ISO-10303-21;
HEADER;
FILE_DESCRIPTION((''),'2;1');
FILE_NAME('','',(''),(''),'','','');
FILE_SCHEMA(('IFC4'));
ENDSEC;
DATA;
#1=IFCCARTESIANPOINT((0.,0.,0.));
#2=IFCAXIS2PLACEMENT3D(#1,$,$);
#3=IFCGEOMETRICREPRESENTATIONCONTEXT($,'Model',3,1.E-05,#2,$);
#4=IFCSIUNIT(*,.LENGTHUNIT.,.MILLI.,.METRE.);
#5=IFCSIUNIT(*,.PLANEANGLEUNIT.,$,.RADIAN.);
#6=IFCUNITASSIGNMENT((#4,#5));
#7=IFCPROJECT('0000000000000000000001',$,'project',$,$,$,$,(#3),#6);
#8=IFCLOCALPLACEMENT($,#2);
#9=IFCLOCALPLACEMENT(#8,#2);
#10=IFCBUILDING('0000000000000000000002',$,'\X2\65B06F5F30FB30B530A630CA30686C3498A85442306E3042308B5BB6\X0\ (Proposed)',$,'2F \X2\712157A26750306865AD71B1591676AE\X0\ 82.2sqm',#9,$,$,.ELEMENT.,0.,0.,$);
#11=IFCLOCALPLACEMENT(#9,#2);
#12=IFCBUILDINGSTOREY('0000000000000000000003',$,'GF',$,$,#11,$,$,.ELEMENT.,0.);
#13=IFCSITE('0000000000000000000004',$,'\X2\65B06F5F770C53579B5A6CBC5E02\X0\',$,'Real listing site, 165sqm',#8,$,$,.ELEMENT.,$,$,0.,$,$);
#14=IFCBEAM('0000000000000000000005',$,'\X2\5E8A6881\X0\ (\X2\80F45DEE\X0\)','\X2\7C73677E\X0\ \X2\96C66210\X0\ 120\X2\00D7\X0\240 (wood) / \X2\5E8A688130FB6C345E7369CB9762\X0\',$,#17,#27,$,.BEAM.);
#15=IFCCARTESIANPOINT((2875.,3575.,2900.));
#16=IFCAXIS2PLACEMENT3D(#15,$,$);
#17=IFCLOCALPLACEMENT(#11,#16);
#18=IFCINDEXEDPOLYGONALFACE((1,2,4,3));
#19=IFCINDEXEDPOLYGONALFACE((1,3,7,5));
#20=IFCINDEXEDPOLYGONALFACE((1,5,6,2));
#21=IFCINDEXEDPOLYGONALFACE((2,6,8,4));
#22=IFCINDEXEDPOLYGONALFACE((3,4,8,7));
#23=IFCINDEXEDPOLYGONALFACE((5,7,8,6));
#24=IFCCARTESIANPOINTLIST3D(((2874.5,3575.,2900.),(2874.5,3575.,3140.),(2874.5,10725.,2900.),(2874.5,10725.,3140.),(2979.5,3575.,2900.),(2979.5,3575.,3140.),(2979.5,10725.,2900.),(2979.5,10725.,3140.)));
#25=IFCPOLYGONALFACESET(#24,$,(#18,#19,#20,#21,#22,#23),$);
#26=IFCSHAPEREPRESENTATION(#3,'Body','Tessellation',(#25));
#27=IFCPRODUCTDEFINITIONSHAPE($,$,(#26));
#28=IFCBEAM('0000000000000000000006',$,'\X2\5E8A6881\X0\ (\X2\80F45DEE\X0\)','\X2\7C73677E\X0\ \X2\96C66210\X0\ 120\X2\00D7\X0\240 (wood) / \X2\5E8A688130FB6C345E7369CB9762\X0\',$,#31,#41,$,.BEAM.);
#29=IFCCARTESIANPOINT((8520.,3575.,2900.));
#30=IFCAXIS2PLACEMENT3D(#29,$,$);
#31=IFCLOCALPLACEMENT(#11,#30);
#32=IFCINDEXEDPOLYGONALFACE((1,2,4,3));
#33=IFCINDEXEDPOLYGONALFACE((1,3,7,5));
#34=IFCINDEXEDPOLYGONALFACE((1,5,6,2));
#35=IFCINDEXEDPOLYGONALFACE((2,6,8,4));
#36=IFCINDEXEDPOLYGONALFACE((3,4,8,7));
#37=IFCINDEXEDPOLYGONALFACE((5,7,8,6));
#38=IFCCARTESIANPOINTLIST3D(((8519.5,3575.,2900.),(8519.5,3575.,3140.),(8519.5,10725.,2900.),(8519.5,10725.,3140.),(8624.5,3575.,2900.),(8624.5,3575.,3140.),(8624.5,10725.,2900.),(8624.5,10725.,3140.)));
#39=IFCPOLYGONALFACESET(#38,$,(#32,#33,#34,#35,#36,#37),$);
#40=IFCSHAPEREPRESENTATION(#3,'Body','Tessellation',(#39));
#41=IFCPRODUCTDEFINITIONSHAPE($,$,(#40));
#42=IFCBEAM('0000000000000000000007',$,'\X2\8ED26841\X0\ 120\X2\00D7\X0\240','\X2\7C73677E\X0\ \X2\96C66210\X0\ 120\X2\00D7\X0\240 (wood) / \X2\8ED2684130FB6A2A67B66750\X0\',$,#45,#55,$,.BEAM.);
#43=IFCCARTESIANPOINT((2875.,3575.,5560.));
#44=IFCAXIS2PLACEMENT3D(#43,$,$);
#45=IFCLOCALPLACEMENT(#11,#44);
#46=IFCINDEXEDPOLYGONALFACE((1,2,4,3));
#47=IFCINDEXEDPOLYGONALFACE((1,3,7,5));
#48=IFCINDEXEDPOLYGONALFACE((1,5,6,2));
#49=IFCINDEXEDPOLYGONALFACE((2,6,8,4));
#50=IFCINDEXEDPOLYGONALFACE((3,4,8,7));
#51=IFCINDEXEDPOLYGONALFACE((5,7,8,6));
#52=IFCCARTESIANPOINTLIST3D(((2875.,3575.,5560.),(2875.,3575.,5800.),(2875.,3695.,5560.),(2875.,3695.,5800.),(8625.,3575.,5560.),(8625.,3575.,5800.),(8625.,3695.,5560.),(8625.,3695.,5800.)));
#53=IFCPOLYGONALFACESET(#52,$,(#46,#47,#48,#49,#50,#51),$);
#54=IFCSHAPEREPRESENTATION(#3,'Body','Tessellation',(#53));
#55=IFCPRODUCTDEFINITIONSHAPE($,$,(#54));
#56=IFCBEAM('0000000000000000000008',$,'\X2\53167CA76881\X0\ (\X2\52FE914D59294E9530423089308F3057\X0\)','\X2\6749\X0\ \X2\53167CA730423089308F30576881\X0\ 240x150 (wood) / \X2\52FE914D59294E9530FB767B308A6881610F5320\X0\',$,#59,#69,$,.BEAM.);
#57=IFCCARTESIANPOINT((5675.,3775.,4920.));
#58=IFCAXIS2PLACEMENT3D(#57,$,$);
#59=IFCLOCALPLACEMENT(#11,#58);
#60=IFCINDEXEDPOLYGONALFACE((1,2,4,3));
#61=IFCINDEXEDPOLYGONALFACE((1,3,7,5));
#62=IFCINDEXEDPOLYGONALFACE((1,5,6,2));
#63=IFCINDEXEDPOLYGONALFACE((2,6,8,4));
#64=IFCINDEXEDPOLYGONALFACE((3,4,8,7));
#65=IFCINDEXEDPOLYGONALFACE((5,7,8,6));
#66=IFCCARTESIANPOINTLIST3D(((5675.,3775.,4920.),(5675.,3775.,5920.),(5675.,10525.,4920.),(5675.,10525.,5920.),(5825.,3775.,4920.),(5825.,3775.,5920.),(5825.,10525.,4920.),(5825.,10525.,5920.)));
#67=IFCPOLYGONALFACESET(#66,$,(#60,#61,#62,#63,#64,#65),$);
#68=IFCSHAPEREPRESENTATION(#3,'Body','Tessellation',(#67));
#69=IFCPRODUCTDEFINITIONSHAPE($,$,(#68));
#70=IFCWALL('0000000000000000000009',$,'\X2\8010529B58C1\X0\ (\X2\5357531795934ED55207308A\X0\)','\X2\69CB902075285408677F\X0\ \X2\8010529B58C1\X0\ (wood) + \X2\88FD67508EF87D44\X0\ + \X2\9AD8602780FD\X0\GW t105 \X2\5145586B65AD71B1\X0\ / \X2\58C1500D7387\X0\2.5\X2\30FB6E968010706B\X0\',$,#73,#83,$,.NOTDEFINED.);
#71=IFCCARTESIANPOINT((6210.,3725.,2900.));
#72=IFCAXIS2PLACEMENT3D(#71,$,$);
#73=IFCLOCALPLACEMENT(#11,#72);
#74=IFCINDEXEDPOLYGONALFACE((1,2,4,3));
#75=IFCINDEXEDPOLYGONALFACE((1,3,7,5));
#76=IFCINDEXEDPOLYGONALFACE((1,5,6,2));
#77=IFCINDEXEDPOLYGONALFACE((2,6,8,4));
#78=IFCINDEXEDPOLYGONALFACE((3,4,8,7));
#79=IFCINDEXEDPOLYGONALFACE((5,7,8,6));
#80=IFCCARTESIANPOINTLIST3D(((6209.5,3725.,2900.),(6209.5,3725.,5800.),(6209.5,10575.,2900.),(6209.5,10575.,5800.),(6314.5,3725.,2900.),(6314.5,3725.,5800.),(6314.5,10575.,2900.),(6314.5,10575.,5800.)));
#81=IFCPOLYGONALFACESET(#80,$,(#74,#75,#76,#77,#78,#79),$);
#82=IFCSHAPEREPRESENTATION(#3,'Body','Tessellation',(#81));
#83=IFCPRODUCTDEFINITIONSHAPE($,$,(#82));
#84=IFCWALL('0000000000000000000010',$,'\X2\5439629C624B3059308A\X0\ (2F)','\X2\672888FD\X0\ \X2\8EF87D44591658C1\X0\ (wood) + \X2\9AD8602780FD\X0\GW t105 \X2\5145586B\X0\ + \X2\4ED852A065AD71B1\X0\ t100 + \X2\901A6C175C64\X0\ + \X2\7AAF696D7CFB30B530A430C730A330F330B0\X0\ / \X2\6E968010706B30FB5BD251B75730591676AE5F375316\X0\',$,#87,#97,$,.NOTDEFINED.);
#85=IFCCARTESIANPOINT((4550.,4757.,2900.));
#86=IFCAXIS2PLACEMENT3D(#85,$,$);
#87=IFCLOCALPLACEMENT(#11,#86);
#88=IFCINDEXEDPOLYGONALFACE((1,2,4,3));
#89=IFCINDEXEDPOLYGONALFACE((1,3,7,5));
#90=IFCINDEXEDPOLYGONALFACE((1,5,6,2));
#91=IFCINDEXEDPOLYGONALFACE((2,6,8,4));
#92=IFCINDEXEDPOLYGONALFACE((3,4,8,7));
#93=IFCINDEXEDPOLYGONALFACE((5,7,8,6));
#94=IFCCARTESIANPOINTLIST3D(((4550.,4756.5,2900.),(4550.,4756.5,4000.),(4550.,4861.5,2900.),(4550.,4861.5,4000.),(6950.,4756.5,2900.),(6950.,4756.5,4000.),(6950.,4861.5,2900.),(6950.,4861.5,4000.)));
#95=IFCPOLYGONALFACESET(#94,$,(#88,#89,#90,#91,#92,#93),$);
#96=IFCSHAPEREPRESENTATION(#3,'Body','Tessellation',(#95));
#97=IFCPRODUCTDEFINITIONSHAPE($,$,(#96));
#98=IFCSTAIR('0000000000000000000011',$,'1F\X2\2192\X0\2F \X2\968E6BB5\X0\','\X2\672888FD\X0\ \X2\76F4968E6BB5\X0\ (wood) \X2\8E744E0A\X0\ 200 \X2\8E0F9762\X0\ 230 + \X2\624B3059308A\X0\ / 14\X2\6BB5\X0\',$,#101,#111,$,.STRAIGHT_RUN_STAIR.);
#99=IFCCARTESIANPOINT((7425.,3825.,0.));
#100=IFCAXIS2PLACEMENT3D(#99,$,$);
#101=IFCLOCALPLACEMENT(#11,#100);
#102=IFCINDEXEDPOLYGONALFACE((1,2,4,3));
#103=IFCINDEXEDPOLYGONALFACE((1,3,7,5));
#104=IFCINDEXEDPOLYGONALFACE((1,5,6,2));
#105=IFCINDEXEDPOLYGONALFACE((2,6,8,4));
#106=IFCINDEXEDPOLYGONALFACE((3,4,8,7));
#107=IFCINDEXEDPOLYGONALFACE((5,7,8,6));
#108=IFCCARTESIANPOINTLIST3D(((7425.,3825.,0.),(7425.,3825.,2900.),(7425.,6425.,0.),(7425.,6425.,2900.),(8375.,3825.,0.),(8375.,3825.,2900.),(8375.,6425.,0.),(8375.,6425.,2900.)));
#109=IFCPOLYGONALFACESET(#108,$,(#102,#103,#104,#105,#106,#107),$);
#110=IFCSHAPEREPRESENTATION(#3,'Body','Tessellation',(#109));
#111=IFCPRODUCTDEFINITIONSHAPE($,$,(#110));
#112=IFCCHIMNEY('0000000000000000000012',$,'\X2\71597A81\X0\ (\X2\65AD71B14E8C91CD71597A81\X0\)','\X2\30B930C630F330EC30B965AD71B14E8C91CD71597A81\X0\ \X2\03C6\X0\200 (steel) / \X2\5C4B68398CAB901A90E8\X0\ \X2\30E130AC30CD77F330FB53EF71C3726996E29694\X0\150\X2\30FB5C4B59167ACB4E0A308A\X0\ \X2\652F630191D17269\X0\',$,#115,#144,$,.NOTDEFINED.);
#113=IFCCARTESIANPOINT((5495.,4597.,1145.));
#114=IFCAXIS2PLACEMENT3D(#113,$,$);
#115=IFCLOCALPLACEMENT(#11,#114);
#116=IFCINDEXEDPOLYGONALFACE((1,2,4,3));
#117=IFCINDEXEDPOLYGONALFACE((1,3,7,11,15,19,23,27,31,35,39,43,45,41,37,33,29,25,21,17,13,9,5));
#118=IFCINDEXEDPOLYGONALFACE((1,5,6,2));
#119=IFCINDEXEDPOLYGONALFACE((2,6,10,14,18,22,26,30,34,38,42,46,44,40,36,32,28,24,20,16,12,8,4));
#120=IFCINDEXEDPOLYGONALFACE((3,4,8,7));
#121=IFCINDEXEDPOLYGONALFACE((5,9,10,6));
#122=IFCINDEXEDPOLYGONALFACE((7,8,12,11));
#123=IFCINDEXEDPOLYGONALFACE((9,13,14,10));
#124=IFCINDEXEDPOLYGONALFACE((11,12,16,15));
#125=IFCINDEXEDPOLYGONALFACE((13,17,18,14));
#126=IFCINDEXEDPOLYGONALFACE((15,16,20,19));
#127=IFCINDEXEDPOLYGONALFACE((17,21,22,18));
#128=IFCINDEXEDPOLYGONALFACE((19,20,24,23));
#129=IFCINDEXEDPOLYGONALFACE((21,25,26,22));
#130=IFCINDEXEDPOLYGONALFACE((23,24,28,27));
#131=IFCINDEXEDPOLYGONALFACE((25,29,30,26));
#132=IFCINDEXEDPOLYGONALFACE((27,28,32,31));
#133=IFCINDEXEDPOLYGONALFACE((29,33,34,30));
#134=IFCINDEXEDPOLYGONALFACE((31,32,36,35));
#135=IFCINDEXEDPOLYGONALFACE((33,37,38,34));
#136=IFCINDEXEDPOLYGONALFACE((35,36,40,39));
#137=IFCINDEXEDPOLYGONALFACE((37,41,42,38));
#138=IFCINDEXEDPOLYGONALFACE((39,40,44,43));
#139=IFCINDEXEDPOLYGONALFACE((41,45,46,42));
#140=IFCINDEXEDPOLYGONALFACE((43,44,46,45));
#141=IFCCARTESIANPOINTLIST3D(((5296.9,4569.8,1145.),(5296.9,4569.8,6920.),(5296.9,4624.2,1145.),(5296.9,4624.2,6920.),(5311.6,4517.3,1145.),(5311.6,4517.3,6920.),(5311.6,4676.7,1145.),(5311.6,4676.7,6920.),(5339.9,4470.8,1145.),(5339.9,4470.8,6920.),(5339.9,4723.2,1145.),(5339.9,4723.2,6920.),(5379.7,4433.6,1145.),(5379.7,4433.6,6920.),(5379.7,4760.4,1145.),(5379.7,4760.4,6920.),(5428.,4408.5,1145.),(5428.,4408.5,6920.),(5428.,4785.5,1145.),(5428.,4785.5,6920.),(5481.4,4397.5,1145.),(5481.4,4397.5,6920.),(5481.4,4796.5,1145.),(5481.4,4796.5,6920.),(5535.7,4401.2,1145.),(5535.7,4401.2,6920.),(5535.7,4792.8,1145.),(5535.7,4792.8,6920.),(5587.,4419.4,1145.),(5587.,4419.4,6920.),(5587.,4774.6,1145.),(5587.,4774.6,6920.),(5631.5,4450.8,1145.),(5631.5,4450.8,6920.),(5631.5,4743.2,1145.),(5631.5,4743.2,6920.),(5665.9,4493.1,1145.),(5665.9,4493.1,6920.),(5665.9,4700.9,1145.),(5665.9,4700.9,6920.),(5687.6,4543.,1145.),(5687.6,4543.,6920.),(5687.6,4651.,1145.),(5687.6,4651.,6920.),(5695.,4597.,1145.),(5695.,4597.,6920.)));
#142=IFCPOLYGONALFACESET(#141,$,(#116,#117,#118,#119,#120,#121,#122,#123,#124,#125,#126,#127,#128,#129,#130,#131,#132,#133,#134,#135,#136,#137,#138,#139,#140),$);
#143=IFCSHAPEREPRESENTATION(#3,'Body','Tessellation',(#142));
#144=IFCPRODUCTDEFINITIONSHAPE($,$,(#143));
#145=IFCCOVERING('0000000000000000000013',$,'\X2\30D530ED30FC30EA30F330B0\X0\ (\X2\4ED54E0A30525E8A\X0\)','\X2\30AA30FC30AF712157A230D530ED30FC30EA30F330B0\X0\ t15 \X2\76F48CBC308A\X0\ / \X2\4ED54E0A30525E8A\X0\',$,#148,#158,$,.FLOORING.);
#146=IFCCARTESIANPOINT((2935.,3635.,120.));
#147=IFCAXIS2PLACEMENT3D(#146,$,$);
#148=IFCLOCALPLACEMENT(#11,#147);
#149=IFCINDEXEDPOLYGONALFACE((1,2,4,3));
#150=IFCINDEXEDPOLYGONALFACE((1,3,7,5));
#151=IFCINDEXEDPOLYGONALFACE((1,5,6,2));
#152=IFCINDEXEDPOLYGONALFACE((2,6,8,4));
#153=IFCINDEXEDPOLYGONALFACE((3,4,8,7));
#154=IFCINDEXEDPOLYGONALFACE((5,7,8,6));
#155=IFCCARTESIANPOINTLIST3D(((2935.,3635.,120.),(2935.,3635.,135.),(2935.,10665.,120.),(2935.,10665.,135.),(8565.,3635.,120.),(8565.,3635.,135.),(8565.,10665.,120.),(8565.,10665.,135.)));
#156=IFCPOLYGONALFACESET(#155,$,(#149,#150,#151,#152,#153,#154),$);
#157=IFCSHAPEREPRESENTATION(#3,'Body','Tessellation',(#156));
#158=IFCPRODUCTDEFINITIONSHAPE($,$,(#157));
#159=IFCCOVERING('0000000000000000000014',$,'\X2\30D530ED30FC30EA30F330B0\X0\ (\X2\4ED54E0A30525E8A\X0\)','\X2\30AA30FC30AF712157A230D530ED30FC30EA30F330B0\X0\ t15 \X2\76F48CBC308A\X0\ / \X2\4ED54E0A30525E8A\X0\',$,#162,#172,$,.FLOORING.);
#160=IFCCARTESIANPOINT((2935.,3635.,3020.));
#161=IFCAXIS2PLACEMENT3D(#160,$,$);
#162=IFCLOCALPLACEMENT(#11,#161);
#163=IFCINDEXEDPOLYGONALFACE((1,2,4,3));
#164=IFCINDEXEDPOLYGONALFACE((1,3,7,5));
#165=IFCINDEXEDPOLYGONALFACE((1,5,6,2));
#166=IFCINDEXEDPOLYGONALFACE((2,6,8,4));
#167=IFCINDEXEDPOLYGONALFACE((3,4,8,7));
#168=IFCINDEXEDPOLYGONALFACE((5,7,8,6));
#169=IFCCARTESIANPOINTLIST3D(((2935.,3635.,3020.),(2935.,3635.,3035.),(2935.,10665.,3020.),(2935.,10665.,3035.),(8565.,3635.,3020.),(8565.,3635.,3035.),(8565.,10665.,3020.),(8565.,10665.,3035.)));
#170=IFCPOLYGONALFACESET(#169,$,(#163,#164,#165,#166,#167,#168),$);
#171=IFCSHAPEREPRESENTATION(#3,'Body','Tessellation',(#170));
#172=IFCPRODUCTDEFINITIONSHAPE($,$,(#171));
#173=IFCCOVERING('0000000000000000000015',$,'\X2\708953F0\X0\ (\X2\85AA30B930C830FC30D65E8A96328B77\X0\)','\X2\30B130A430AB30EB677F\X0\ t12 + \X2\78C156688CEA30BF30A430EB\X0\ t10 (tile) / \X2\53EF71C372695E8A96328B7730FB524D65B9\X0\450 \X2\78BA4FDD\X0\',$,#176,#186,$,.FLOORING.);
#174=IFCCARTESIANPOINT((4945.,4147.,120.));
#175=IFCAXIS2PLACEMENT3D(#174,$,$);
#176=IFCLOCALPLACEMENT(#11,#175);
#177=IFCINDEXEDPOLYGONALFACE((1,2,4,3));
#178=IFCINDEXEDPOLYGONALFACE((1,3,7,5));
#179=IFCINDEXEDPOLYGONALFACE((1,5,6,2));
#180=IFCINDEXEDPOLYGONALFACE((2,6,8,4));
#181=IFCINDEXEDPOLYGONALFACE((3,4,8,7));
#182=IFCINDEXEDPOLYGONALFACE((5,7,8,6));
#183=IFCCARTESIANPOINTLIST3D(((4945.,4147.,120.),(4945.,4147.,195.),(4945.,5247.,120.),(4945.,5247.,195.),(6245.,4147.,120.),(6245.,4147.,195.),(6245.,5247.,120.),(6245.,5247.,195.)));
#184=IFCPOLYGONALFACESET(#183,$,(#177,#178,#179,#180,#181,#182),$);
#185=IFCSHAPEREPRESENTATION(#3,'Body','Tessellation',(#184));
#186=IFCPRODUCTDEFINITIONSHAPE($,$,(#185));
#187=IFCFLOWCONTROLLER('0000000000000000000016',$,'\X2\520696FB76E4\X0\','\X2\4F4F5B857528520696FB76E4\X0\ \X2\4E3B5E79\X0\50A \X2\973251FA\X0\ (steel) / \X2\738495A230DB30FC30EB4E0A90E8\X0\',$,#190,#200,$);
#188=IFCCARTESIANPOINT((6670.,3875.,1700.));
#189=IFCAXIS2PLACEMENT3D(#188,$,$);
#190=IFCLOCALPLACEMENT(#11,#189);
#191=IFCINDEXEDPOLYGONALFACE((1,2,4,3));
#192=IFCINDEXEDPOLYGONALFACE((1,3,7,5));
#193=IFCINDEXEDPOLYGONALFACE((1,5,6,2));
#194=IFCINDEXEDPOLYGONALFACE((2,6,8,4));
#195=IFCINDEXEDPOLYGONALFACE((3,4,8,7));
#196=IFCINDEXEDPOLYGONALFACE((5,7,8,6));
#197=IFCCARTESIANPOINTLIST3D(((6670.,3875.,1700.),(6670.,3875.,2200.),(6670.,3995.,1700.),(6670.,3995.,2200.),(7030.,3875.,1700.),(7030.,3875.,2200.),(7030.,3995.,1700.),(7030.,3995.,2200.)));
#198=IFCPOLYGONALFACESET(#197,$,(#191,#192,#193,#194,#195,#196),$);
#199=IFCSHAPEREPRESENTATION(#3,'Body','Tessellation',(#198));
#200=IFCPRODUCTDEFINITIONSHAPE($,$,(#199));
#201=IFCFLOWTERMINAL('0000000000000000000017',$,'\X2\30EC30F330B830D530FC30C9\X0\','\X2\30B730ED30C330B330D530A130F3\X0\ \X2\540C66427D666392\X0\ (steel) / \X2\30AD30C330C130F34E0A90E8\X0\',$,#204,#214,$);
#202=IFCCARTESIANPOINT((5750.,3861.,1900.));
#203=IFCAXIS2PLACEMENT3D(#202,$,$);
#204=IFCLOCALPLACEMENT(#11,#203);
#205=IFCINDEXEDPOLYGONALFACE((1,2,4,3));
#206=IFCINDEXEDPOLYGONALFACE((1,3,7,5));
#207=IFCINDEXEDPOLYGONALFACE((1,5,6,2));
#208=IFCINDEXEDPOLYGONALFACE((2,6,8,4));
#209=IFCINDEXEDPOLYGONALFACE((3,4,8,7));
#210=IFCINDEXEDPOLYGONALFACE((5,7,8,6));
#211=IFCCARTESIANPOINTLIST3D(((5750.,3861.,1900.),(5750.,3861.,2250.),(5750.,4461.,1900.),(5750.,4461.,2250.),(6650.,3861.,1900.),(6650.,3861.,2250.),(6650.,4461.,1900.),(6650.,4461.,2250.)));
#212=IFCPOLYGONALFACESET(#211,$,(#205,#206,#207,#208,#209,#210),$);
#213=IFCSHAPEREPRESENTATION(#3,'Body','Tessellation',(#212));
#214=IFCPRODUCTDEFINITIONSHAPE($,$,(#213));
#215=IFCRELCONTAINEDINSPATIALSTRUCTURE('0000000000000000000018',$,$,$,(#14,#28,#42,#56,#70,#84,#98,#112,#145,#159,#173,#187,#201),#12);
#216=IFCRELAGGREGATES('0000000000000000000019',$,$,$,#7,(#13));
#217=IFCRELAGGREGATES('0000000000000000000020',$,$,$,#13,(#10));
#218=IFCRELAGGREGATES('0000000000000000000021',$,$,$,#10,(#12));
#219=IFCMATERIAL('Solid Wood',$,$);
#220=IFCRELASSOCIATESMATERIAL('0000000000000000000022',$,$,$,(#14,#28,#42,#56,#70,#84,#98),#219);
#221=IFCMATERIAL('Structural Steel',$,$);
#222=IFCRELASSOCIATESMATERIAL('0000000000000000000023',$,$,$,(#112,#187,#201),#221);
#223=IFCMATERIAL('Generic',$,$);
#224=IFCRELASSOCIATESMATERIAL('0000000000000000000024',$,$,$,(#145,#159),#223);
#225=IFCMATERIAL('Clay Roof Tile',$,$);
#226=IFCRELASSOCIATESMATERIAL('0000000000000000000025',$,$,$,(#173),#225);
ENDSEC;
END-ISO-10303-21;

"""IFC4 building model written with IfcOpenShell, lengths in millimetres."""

from ifc_helpers import new_model, si_unit, frame, frame_2d, origin, origin_2d, place, context, project, spatial, rectangle, circle, extrude, material, element, save


model = new_model("IFC4")

# Units and contexts
model_context = context("Model", 3, precision=1e-05, world=origin())
ifc_project = project(units=[si_unit("LENGTHUNIT", "METRE", prefix="MILLI"), si_unit("PLANEANGLEUNIT", "RADIAN")], contexts=[model_context])

# Site, building, storey
site_placement = place(None, origin())
site = spatial("IfcSite", under=ifc_project, at=site_placement, Name="新潟県南魚沼市", ObjectType="Real listing site, 165sqm", CompositionType="ELEMENT", RefElevation=0.0)
building_placement = place(site_placement, origin())
building = spatial("IfcBuilding", under=site, at=building_placement, Name="新潟・サウナと水風呂のある家 (Proposed)", ObjectType="2F 無垢材と断熱外皮 82.2sqm", CompositionType="ELEMENT", ElevationOfRefHeight=0.0, ElevationOfTerrain=0.0)
storey_placement = place(building_placement, origin())
storey = spatial("IfcBuildingStorey", under=building, at=storey_placement, Name="GF", CompositionType="ELEMENT", Elevation=0.0)

# Beams
ifc_material_1 = material(Name="Solid Wood")
beam_1_placement = place(storey_placement, frame((2875.0, 3575.0, 2900.0)))
element("IfcBeam", 1, at=beam_1_placement, inside=storey, material=ifc_material_1, Name="床梁 (胴差)", Description="米松 集成 120×240 (wood) / 床梁・水平構面", PredefinedType="BEAM", context=model_context, shape_type="SweptSolid", body=[
    extrude(rectangle(XDim=105.0, YDim=7150.0, at=frame_2d((52.0, 3575.0))), frame((2875.0, 3575.0, 2900.0)), (0.0, 0.0, 1.0), 240.0),
])
beam_2_placement = place(storey_placement, frame((8520.0, 3575.0, 2900.0)))
element("IfcBeam", 2, at=beam_2_placement, inside=storey, material=ifc_material_1, Name="床梁 (胴差)", Description="米松 集成 120×240 (wood) / 床梁・水平構面", PredefinedType="BEAM", context=model_context, shape_type="SweptSolid", body=[
    extrude(rectangle(XDim=105.0, YDim=7150.0, at=frame_2d((52.0, 3575.0))), frame((8520.0, 3575.0, 2900.0)), (0.0, 0.0, 1.0), 240.0),
])
beam_3_placement = place(storey_placement, frame((2875.0, 3575.0, 5560.0)))
element("IfcBeam", 3, at=beam_3_placement, inside=storey, material=ifc_material_1, Name="軒桁 120×240", Description="米松 集成 120×240 (wood) / 軒桁・横架材", PredefinedType="BEAM", context=model_context, shape_type="SweptSolid", body=[
    extrude(rectangle(XDim=5750.0, YDim=120.0, at=frame_2d((2875.0, 60.0))), frame((2875.0, 3575.0, 5560.0)), (0.0, 0.0, 1.0), 240.0),
])
beam_4_placement = place(storey_placement, frame((5675.0, 3775.0, 4920.0)))
element("IfcBeam", 4, at=beam_4_placement, inside=storey, material=ifc_material_1, Name="化粧梁 (勾配天井あらわし)", Description="杉 化粧あらわし梁 240x150 (wood) / 勾配天井・登り梁意匠", PredefinedType="BEAM", context=model_context, shape_type="SweptSolid", body=[
    extrude(rectangle(XDim=150.0, YDim=6750.0, at=frame_2d((75.0, 3375.0))), frame((5675.0, 3775.0, 4920.0)), (0.0, 0.0, 1.0), 1000.0),
])

# Walls
wall_1_placement = place(storey_placement, frame((6210.0, 3725.0, 2900.0)))
element("IfcWall", 5, at=wall_1_placement, inside=storey, material=ifc_material_1, Name="耐力壁 (南北間仕切り)", Description="構造用合板 耐力壁 (wood) + 製材軸組 + 高性能GW t105 充填断熱 / 壁倍率2.5・準耐火", PredefinedType="NOTDEFINED", context=model_context, shape_type="SweptSolid", body=[
    extrude(rectangle(XDim=105.0, YDim=6850.0, at=frame_2d((52.0, 3425.0))), frame((6210.0, 3725.0, 2900.0)), (0.0, 0.0, 1.0), 2900.0),
])
wall_2_placement = place(storey_placement, frame((4550.0, 4757.0, 2900.0)))
element("IfcWall", 6, at=wall_2_placement, inside=storey, material=ifc_material_1, Name="吹抜手すり (2F)", Description="木製 軸組外壁 (wood) + 高性能GW t105 充填 + 付加断熱 t100 + 通気層 + 窯業系サイディング / 準耐火・寒冷地外皮強化", PredefinedType="NOTDEFINED", context=model_context, shape_type="SweptSolid", body=[
    extrude(rectangle(XDim=2400.0, YDim=105.0, at=frame_2d((1200.0, 52.0))), frame((4550.0, 4757.0, 2900.0)), (0.0, 0.0, 1.0), 1100.0),
])

# Stair
stair_placement = place(storey_placement, frame((7425.0, 3825.0, 0.0)))
element("IfcStair", 7, at=stair_placement, inside=storey, material=ifc_material_1, Name="1F→2F 階段", Description="木製 直階段 (wood) 蹴上 200 踏面 230 + 手すり / 14段", PredefinedType="STRAIGHT_RUN_STAIR", context=model_context, shape_type="SweptSolid", body=[
    extrude(rectangle(XDim=950.0, YDim=2600.0, at=frame_2d((475.0, 1300.0))), frame((7425.0, 3825.0, 0.0)), (0.0, 0.0, 1.0), 2900.0),
])

# Chimney
ifc_material_2 = material(Name="Structural Steel")
chimney_placement = place(storey_placement, frame((5495.0, 4597.0, 1145.0)))
element("IfcChimney", 8, at=chimney_placement, inside=storey, material=ifc_material_2, Name="煙突 (断熱二重煙突)", Description="ステンレス断熱二重煙突 φ200 (steel) / 屋根貫通部 メガネ石・可燃物離隔150・屋外立上り 支持金物", PredefinedType="NOTDEFINED", context=model_context, shape_type="SweptSolid", body=[
    extrude(circle(Radius=200.0, at=origin_2d()), frame((5495.0, 4597.0, 1145.0)), (0.0, 0.0, 1.0), 5775.0),
])

# Coverings
ifc_material_3 = material(Name="Generic")
covering_1_placement = place(storey_placement, frame((2935.0, 3635.0, 120.0)))
element("IfcCovering", 9, at=covering_1_placement, inside=storey, material=ifc_material_3, Name="フローリング (仕上げ床)", Description="オーク無垢フローリング t15 直貼り / 仕上げ床", PredefinedType="FLOORING", context=model_context, shape_type="SweptSolid", body=[
    extrude(rectangle(XDim=5630.0, YDim=7030.0, at=frame_2d((2815.0, 3515.0))), frame((2935.0, 3635.0, 120.0)), (0.0, 0.0, 1.0), 15.0),
])
covering_2_placement = place(storey_placement, frame((2935.0, 3635.0, 3020.0)))
element("IfcCovering", 10, at=covering_2_placement, inside=storey, material=ifc_material_3, Name="フローリング (仕上げ床)", Description="オーク無垢フローリング t15 直貼り / 仕上げ床", PredefinedType="FLOORING", context=model_context, shape_type="SweptSolid", body=[
    extrude(rectangle(XDim=5630.0, YDim=7030.0, at=frame_2d((2815.0, 3515.0))), frame((2935.0, 3635.0, 3020.0)), (0.0, 0.0, 1.0), 15.0),
])
ifc_material_4 = material(Name="Clay Roof Tile")
covering_3_placement = place(storey_placement, frame((4945.0, 4147.0, 120.0)))
element("IfcCovering", 11, at=covering_3_placement, inside=storey, material=ifc_material_4, Name="炉台 (薪ストーブ床防護)", Description="ケイカル板 t12 + 磁器質タイル t10 (tile) / 可燃物床防護・前方450 確保", PredefinedType="FLOORING", context=model_context, shape_type="SweptSolid", body=[
    extrude(rectangle(XDim=1300.0, YDim=1100.0, at=frame_2d((650.0, 550.0))), frame((4945.0, 4147.0, 120.0)), (0.0, 0.0, 1.0), 75.0),
])

# Flow controller
flow_controller_placement = place(storey_placement, frame((6670.0, 3875.0, 1700.0)))
element("IfcFlowController", 12, at=flow_controller_placement, inside=storey, material=ifc_material_2, Name="分電盤", Description="住宅用分電盤 主幹50A 露出 (steel) / 玄関ホール上部", context=model_context, shape_type="SweptSolid", body=[
    extrude(rectangle(XDim=360.0, YDim=120.0, at=frame_2d((180.0, 60.0))), frame((6670.0, 3875.0, 1700.0)), (0.0, 0.0, 1.0), 500.0),
])

# Flow terminal
flow_terminal_1_placement = place(storey_placement, frame((5750.0, 3861.0, 1900.0)))
element("IfcFlowTerminal", 13, at=flow_terminal_1_placement, inside=storey, material=ifc_material_2, Name="レンジフード", Description="シロッコファン 同時給排 (steel) / キッチン上部", context=model_context, shape_type="SweptSolid", body=[
    extrude(rectangle(XDim=900.0, YDim=600.0, at=frame_2d((450.0, 300.0))), frame((5750.0, 3861.0, 1900.0)), (0.0, 0.0, 1.0), 350.0),
])

save(model, "model.ifc")
